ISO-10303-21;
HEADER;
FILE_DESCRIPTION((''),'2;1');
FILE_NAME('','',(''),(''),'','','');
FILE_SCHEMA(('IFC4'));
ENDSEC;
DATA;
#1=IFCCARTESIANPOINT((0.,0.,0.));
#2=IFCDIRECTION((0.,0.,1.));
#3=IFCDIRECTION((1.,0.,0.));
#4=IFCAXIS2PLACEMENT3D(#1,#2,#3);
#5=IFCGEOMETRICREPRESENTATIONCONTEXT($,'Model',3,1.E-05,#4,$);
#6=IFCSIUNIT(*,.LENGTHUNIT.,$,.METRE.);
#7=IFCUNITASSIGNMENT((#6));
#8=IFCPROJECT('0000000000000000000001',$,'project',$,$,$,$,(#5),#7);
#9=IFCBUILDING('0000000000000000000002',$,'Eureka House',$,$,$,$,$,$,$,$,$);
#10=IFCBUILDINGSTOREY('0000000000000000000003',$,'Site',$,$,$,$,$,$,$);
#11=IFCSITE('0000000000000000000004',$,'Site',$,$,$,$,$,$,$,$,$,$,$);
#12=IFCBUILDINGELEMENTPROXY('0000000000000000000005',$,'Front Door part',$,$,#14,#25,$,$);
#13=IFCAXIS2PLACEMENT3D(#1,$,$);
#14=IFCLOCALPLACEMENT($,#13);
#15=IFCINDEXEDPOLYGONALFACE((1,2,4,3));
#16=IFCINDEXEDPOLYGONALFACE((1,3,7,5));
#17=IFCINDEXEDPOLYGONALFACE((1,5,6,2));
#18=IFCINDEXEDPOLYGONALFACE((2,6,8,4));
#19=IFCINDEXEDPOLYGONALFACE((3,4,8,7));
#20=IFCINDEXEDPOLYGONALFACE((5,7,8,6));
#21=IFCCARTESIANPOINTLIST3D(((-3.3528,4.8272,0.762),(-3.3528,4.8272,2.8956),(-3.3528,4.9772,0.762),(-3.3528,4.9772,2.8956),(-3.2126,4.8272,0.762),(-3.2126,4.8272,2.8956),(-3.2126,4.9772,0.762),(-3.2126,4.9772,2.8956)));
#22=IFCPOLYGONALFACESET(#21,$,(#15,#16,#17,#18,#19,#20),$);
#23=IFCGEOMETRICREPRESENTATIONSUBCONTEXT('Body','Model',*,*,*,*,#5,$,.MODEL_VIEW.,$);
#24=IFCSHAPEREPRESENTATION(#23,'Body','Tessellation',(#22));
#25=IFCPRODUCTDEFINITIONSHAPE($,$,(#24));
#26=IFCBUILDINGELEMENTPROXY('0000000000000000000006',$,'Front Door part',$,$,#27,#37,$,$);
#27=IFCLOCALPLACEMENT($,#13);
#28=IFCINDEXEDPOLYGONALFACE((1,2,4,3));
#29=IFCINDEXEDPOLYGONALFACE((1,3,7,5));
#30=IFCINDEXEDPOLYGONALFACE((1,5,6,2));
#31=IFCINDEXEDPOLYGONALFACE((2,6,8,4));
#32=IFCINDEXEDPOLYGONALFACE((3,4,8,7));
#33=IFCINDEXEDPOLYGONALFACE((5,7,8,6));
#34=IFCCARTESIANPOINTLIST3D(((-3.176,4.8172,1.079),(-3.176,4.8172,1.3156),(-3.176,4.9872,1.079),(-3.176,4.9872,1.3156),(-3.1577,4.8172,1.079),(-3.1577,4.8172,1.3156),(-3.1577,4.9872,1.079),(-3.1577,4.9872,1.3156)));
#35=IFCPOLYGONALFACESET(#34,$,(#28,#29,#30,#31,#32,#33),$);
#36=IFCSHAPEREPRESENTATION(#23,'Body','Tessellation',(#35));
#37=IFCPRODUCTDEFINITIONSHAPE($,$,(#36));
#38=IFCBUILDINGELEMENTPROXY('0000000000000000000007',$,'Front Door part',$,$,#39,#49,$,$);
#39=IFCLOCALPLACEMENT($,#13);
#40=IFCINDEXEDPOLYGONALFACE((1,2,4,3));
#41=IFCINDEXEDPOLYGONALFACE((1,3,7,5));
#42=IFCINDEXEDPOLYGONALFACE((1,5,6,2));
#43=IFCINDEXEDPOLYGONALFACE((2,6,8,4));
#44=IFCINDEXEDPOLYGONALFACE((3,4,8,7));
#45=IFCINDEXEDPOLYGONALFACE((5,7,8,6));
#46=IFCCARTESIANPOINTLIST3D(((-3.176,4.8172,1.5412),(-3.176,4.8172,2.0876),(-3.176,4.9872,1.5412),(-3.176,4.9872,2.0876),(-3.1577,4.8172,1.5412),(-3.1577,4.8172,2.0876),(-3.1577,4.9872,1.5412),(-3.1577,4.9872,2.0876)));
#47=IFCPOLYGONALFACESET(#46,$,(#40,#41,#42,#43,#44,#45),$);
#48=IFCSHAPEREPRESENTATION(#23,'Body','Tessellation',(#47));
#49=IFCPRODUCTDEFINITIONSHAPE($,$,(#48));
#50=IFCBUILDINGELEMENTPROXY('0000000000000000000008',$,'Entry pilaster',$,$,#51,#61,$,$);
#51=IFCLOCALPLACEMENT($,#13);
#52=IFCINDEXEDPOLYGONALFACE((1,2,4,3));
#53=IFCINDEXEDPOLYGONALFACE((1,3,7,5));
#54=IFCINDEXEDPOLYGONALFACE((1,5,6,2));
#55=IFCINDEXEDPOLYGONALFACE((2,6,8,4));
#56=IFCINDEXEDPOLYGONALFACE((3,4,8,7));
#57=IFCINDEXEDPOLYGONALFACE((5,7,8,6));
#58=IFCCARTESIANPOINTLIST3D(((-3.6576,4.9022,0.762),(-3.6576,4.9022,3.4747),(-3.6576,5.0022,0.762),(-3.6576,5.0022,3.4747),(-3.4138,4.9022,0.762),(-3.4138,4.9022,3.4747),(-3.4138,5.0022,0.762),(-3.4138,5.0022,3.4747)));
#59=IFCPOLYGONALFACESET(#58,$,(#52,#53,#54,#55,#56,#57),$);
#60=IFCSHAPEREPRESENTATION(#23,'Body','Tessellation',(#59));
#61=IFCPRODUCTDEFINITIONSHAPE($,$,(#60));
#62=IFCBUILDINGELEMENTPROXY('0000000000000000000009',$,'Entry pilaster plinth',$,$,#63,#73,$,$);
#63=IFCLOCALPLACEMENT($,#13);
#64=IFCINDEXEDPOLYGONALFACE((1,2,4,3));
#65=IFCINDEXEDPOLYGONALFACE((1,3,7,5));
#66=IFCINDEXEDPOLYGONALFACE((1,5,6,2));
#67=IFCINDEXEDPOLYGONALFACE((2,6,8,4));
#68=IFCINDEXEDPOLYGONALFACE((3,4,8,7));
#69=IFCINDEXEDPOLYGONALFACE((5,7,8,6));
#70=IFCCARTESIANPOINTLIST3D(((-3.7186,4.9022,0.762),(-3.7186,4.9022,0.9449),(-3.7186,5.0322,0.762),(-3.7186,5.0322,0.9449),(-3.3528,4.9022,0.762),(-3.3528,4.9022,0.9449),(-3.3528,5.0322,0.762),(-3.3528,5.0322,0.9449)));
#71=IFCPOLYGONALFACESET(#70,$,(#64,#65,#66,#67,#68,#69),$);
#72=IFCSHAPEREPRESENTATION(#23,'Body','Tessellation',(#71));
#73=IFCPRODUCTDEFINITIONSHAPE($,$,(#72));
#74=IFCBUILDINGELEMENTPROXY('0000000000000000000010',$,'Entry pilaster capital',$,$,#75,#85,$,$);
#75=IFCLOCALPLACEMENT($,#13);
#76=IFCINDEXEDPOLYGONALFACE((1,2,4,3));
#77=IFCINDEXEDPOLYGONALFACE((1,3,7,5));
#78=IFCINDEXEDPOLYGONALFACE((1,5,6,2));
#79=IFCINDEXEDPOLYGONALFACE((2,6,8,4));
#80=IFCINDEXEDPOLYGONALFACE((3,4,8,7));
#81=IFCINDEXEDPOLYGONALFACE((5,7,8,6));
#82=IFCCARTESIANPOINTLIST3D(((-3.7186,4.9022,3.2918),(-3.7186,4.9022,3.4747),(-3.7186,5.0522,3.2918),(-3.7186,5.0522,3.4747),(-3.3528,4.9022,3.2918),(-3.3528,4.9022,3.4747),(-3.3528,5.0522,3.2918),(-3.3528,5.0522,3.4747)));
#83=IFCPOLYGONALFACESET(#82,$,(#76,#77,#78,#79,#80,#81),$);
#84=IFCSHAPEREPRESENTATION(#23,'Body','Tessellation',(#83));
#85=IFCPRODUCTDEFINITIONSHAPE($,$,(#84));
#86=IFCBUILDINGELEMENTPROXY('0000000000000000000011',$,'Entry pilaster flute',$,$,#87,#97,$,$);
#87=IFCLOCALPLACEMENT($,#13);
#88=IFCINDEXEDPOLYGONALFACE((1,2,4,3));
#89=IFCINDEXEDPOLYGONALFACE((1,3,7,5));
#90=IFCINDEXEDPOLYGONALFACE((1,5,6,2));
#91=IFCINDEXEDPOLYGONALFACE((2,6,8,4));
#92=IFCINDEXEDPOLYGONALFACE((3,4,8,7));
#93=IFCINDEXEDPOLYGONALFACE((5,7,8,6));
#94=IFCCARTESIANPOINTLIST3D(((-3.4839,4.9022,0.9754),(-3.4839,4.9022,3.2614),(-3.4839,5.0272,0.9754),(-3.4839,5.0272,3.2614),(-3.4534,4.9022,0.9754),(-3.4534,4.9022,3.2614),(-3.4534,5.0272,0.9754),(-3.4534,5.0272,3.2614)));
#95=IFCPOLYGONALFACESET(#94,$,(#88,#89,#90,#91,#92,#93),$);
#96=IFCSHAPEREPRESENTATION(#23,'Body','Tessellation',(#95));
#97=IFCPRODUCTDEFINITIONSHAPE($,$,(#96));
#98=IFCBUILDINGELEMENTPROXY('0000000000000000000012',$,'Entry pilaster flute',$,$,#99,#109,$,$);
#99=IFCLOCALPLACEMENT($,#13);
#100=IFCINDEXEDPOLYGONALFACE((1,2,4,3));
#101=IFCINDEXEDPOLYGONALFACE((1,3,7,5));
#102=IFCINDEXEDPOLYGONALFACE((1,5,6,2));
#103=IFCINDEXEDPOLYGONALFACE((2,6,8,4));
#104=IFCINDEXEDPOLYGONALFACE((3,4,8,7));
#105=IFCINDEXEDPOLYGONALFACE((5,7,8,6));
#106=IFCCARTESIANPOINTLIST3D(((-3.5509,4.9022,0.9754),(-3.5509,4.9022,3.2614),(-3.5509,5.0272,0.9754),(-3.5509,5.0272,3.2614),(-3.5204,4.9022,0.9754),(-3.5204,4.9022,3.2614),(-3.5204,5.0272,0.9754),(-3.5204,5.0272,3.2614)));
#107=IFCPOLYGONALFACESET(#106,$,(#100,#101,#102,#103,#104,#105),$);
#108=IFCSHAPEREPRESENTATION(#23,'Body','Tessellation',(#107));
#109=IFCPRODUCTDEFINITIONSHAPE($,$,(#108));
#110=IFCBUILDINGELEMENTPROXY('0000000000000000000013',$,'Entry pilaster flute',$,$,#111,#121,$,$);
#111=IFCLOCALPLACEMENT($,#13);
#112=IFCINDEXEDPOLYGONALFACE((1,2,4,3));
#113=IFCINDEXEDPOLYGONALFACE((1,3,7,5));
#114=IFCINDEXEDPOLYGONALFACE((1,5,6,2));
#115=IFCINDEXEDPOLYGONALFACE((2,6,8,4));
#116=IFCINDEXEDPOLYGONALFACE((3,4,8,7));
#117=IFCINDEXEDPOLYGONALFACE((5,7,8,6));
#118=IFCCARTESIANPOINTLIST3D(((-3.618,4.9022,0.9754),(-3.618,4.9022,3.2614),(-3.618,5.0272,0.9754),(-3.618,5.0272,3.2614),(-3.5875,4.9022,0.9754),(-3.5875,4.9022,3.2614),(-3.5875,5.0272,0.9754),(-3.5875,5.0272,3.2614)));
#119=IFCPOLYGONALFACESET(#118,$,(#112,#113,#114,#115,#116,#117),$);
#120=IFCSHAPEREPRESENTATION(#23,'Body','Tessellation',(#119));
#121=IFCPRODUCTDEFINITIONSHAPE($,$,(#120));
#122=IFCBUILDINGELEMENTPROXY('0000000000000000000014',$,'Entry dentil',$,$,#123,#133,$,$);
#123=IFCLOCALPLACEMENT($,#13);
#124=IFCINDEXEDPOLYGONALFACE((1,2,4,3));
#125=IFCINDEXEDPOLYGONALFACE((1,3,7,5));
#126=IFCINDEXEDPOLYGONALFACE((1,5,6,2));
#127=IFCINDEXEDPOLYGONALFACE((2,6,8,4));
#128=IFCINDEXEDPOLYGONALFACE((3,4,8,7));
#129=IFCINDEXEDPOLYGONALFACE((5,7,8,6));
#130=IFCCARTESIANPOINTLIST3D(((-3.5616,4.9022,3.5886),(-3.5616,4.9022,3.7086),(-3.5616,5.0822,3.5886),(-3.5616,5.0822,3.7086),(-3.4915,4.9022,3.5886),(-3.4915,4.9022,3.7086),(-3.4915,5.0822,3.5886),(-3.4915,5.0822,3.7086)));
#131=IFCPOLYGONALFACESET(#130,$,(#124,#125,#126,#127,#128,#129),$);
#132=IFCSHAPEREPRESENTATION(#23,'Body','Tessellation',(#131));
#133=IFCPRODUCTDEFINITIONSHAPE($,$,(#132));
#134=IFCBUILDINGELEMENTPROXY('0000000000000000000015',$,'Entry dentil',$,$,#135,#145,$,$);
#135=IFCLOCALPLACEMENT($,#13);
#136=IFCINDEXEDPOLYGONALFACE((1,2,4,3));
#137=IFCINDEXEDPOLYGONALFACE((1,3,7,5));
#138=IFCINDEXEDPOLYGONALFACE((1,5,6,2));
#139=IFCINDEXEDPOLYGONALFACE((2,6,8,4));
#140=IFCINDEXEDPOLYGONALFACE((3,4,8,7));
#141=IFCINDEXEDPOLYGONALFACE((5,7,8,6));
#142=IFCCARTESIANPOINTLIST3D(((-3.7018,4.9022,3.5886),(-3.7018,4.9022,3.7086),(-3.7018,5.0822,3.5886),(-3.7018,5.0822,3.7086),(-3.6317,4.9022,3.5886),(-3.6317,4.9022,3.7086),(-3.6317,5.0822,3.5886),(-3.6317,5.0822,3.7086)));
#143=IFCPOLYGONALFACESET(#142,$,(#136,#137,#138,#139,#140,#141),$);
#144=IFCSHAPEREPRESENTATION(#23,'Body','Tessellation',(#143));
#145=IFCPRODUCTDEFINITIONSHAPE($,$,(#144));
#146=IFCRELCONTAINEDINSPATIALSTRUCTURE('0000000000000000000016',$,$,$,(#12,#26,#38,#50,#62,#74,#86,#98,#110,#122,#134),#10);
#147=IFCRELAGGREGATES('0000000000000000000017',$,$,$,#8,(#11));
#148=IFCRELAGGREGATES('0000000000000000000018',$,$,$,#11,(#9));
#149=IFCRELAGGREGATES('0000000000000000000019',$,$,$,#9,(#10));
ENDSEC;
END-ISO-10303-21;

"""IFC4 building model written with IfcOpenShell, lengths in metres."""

from ifc_helpers import new_model, si_unit, frame, origin, origin_with_axes, origin_2d, place, context, subcontext, project, spatial, rectangle, extrude, element, save


model = new_model("IFC4")

# Units and contexts
model_context = context("Model", 3, precision=1e-05, world=origin_with_axes())
body_context = subcontext(model_context, "Body", "Model", "MODEL_VIEW")
ifc_project = project(units=[si_unit("LENGTHUNIT", "METRE")], contexts=[model_context])

# Site, building, storey
site = spatial("IfcSite", under=ifc_project, Name="Site")
building = spatial("IfcBuilding", under=site, Name="Eureka House")
storey = spatial("IfcBuildingStorey", under=building, Name="Site")

# Building element proxies
proxy_1_placement = place(None, frame((-3.2827, 4.9022, 0.762), z_axis=(0.0, 0.0, 1.0), x_axis=(1.0, 0.0, 0.0)))
element("IfcBuildingElementProxy", 1, at=proxy_1_placement, inside=storey, Name="Front Door part", context=body_context, shape_type="SweptSolid", body=[
    extrude(rectangle(XDim=0.1402, YDim=0.15, at=origin_2d()), origin(), (0.0, 0.0, 1.0), 2.1336),
])
proxy_2_placement = place(None, frame((-3.1669, 4.9022, 1.079), z_axis=(0.0, 0.0, 1.0), x_axis=(1.0, 0.0, 0.0)))
element("IfcBuildingElementProxy", 2, at=proxy_2_placement, inside=storey, Name="Front Door part", context=body_context, shape_type="SweptSolid", body=[
    extrude(rectangle(XDim=0.0183, YDim=0.17, at=origin_2d()), origin(), (0.0, 0.0, 1.0), 0.2366),
])
proxy_3_placement = place(None, frame((-3.1669, 4.9022, 1.5412), z_axis=(0.0, 0.0, 1.0), x_axis=(1.0, 0.0, 0.0)))
element("IfcBuildingElementProxy", 3, at=proxy_3_placement, inside=storey, Name="Front Door part", context=body_context, shape_type="SweptSolid", body=[
    extrude(rectangle(XDim=0.0183, YDim=0.17, at=origin_2d()), origin(), (0.0, 0.0, 1.0), 0.5464),
])
proxy_4_placement = place(None, frame((-3.5357, 4.9522, 0.762), z_axis=(0.0, 0.0, 1.0), x_axis=(1.0, 0.0, 0.0)))
element("IfcBuildingElementProxy", 4, at=proxy_4_placement, inside=storey, Name="Entry pilaster", context=body_context, shape_type="SweptSolid", body=[
    extrude(rectangle(XDim=0.2438, YDim=0.1, at=origin_2d()), origin(), (0.0, 0.0, 1.0), 2.7127),
])
proxy_5_placement = place(None, frame((-3.5357, 4.9672, 0.762), z_axis=(0.0, 0.0, 1.0), x_axis=(1.0, 0.0, 0.0)))
element("IfcBuildingElementProxy", 5, at=proxy_5_placement, inside=storey, Name="Entry pilaster plinth", context=body_context, shape_type="SweptSolid", body=[
    extrude(rectangle(XDim=0.3658, YDim=0.13, at=origin_2d()), origin(), (0.0, 0.0, 1.0), 0.1829),
])
proxy_6_placement = place(None, frame((-3.5357, 4.9772, 3.2918), z_axis=(0.0, 0.0, 1.0), x_axis=(1.0, 0.0, 0.0)))
element("IfcBuildingElementProxy", 6, at=proxy_6_placement, inside=storey, Name="Entry pilaster capital", context=body_context, shape_type="SweptSolid", body=[
    extrude(rectangle(XDim=0.3658, YDim=0.15, at=origin_2d()), origin(), (0.0, 0.0, 1.0), 0.1829),
])
for number, where, z_axis, x_axis, name in (
    (7, (-3.4686, 4.9647, 0.9754), (0.0, 0.0, 1.0), (1.0, 0.0, 0.0), "Entry pilaster flute"),
    (8, (-3.5357, 4.9647, 0.9754), (0.0, 0.0, 1.0), (1.0, 0.0, 0.0), "Entry pilaster flute"),
    (9, (-3.6027, 4.9647, 0.9754), (0.0, 0.0, 1.0), (1.0, 0.0, 0.0), "Entry pilaster flute"),
):
    element("IfcBuildingElementProxy", number, at=place(None, frame(where, z_axis=z_axis, x_axis=x_axis)), inside=storey, Name=name, context=body_context, shape_type="SweptSolid", body=[
        extrude(rectangle(XDim=0.0305, YDim=0.125, at=origin_2d()), origin(), (0.0, 0.0, 1.0), 2.286),
    ])
for number, where, z_axis, x_axis, name in (
    (10, (-3.5265, 4.9922, 3.5886), (0.0, 0.0, 1.0), (1.0, 0.0, 0.0), "Entry dentil"),
    (11, (-3.6667, 4.9922, 3.5886), (0.0, 0.0, 1.0), (1.0, 0.0, 0.0), "Entry dentil"),
):
    element("IfcBuildingElementProxy", number, at=place(None, frame(where, z_axis=z_axis, x_axis=x_axis)), inside=storey, Name=name, context=body_context, shape_type="SweptSolid", body=[
        extrude(rectangle(XDim=0.0701, YDim=0.18, at=origin_2d()), origin(), (0.0, 0.0, 1.0), 0.12),
    ])

save(model, "model.ifc")
